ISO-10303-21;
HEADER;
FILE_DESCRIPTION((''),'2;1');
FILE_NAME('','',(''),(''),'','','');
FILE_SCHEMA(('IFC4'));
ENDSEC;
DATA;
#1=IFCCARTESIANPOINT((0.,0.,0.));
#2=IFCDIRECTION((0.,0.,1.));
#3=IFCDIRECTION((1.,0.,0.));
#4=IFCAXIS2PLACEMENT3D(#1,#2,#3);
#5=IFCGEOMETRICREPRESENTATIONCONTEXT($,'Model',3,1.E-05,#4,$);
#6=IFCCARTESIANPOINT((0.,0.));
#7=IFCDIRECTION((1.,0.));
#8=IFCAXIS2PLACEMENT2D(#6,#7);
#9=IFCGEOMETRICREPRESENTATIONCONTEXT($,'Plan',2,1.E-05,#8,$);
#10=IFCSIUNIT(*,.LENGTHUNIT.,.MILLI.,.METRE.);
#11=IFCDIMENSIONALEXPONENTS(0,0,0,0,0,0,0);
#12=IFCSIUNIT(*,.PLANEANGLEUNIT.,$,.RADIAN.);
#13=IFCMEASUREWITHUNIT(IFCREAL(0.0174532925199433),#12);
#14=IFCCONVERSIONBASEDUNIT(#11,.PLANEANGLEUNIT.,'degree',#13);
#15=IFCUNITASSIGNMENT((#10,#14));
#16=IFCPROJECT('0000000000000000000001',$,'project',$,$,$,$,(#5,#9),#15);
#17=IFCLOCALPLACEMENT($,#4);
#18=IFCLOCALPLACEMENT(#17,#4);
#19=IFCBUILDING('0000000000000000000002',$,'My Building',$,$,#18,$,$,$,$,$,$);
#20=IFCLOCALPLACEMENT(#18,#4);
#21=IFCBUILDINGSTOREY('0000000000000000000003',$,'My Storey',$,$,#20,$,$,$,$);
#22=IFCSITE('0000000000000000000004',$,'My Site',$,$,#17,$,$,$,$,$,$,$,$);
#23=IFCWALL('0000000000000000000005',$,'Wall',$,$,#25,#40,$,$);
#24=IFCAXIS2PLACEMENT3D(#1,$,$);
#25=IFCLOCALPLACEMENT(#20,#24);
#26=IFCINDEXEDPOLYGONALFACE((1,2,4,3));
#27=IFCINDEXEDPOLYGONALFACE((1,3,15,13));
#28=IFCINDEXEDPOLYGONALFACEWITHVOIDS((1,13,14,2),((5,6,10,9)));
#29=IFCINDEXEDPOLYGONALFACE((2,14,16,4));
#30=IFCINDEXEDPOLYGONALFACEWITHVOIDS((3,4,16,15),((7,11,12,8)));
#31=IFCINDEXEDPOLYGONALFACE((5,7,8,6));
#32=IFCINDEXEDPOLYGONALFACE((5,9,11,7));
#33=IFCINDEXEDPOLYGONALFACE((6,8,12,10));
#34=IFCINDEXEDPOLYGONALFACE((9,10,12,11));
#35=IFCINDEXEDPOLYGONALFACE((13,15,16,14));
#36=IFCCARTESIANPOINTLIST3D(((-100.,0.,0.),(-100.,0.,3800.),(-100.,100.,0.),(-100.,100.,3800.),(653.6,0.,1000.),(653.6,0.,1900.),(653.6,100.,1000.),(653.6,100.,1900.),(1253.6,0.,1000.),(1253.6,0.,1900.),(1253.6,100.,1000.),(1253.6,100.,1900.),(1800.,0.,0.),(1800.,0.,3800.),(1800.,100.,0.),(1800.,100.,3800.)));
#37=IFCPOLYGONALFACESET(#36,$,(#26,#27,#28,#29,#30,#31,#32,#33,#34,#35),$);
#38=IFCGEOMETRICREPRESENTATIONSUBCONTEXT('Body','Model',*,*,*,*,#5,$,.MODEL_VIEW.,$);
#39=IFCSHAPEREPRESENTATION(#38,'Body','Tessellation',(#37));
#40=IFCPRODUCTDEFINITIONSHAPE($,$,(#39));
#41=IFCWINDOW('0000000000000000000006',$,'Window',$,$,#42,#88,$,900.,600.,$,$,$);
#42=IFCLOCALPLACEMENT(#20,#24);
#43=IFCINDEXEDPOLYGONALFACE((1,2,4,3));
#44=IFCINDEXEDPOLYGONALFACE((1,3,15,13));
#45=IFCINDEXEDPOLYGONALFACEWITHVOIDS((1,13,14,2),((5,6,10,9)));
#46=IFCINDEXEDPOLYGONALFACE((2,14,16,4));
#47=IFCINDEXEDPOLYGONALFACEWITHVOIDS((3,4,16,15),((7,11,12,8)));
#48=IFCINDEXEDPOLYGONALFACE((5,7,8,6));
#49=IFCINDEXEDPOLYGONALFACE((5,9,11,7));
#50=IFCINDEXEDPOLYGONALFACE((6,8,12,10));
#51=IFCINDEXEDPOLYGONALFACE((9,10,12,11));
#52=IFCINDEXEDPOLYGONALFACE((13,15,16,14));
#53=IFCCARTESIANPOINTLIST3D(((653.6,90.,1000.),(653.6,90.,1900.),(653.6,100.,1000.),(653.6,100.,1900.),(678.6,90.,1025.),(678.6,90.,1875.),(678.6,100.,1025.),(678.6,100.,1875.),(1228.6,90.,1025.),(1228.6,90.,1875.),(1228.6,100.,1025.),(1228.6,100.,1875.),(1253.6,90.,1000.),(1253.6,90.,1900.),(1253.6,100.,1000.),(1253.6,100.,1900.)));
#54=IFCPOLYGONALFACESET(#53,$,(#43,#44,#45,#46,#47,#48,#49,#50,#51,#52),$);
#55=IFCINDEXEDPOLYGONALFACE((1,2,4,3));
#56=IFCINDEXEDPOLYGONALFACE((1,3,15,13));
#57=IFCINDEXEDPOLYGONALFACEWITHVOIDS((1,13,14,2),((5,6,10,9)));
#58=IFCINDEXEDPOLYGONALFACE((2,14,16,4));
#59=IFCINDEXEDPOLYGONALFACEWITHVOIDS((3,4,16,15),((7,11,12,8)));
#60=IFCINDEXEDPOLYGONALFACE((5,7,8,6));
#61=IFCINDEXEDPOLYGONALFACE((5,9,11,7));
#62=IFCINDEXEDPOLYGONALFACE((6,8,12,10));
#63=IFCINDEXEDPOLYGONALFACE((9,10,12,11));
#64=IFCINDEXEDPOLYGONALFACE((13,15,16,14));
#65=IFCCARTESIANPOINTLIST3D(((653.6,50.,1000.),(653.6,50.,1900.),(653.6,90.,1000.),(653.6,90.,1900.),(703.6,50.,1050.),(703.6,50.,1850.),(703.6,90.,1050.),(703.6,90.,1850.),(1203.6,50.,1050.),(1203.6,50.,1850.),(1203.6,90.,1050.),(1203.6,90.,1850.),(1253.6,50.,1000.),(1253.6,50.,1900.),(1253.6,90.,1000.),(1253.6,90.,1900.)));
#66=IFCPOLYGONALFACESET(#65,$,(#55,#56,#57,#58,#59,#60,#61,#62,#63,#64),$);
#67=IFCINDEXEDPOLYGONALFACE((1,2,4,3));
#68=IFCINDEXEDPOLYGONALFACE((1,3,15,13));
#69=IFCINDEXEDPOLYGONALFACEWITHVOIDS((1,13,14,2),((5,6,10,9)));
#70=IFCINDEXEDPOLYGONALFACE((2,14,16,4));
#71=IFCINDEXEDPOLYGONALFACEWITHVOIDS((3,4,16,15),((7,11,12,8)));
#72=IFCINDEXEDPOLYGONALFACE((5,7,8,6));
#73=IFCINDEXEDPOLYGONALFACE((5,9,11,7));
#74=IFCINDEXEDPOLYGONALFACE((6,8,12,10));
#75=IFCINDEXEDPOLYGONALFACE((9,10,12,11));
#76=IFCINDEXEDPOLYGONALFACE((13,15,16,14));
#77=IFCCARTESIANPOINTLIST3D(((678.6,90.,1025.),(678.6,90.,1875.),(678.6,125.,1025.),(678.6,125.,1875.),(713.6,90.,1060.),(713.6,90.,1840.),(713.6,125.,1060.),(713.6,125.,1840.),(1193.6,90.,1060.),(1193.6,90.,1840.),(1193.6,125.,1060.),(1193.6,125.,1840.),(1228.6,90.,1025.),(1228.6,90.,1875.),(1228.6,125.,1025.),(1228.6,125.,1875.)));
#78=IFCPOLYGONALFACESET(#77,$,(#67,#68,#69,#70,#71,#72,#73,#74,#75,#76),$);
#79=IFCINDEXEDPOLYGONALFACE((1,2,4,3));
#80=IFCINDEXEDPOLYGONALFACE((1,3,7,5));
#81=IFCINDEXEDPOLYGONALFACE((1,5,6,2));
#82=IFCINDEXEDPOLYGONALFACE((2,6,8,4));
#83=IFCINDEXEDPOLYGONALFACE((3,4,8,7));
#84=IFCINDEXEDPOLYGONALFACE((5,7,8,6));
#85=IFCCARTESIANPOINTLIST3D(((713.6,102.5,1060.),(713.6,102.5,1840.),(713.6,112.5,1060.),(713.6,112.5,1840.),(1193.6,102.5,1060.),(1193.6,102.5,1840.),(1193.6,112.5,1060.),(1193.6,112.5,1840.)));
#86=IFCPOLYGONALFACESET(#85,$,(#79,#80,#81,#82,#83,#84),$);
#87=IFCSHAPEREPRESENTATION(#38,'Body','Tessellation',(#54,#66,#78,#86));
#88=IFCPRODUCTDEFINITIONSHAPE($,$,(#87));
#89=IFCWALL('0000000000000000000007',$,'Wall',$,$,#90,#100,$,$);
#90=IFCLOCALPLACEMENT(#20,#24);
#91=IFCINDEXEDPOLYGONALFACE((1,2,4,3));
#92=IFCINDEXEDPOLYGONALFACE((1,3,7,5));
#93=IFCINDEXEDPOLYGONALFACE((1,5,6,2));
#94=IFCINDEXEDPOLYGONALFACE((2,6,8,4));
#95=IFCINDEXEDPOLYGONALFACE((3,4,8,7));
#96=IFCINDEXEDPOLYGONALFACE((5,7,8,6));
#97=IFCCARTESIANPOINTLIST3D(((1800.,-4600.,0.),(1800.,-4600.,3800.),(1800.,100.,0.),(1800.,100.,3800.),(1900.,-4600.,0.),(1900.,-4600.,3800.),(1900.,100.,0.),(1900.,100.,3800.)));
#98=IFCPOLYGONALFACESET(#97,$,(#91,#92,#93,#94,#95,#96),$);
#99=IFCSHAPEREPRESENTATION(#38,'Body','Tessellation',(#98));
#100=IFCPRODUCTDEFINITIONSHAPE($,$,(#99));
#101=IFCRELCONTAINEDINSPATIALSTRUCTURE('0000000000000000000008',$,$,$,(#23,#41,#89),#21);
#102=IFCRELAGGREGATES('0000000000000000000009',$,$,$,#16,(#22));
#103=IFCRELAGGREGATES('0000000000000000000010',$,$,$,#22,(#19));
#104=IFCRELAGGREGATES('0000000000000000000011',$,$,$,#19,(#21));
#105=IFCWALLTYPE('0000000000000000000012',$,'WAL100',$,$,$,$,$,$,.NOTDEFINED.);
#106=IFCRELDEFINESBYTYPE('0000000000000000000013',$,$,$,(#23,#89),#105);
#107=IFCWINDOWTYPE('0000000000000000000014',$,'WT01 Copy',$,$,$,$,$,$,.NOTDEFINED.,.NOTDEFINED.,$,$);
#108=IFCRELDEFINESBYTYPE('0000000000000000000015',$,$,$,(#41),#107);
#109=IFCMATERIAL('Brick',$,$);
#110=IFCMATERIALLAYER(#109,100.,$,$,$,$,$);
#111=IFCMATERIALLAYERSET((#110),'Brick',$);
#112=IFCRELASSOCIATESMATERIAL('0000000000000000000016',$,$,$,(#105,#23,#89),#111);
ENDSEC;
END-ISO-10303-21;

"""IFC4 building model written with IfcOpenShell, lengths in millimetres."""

from ifc_helpers import new_model, entity, si_unit, converted_unit, frame, origin_with_axes, origin_2d_with_axis, place, context, subcontext, project, spatial, line, indexed_curve, outline, extrude, shape, source, transform, mapped, material, layer, layer_set, layer_usage, type_object, type_shapes, element, fill, save


model = new_model("IFC4")

# Units and contexts
model_context = context("Model", 3, precision=1e-05, world=origin_with_axes())
plan_context = context("Plan", 2, precision=1e-05, world=origin_2d_with_axis())
body_context_1 = subcontext(model_context, "Body", "Model", "MODEL_VIEW")
body_context_2 = subcontext(plan_context, "Body", "Plan", "PLAN_VIEW")
ifc_project = project(units=[si_unit("LENGTHUNIT", "METRE", prefix="MILLI"), converted_unit("PLANEANGLEUNIT", "degree", entity("IfcReal", 0.0174532925199433), si_unit("PLANEANGLEUNIT", "RADIAN"), dimensions=[0, 0, 0, 0, 0, 0, 0])], contexts=[model_context, plan_context])

# Site, building, storey
site_placement = place(None, origin_with_axes())
site = spatial("IfcSite", under=ifc_project, at=site_placement, Name="My Site")
building_placement = place(site_placement, origin_with_axes())
building = spatial("IfcBuilding", under=site, at=building_placement, Name="My Building")
storey_placement = place(building_placement, origin_with_axes())
storey = spatial("IfcBuildingStorey", under=building, at=storey_placement, Name="My Storey")

# Wall, opening, window
ifc_material = material(Name="Brick")
ifc_layer_1 = layer(ifc_material, 100.0)
ifc_layer_set_1 = layer_set([ifc_layer_1], Name="Brick")
ifc_layer_usage_1 = layer_usage(ifc_layer_set_1, "AXIS2", "POSITIVE", 0.0)
wall_type = type_object("IfcWallType", Name="WAL100", PredefinedType="NOTDEFINED", material=ifc_layer_set_1)
wall_1_placement = place(storey_placement, frame((-100.0, 0.0, 0.0), z_axis=(0.0, 0.0, 1.0), x_axis=(1.0, 0.0, 0.0)))
wall_1 = element("IfcWall", 1, at=wall_1_placement, inside=storey, type_object=wall_type, material=ifc_layer_usage_1, Name="Wall", context=body_context_1, shape_type="SweptSolid", body=[
    extrude(outline(indexed_curve([(0.0, 0.0), (0.0, 100.0), (1900.0, 100.0), (1900.0, 0.0), (0.0, 0.0)], self_intersect=False)), origin_with_axes(), (0.0, 0.0, 1.0), 3800.0),
])
shared_shape_1 = source(origin_with_axes(), body_context_1, "Body", "SweptSolid", [
    extrude(outline(indexed_curve([(0.0, 0.0), (600.0, 0.0), (600.0, 900.0), (0.0, 900.0)], segments=[line(1, 2, 3, 4, 1)])), frame((0.0, -100.0, 0.0), z_axis=(0.0, -1.0, 0.0), x_axis=(1.0, 0.0, 0.0)), (0.0, 0.0, -1.0), 300.0),
])
opening_1_placement = place(wall_1_placement, frame((753.6, 0.0, 1000.0), z_axis=(0.0, 0.0, 1.0), x_axis=(1.0, 0.0, 0.0)))
opening_1 = element("IfcOpeningElement", 2, at=opening_1_placement, cuts=wall_1, PredefinedType="OPENING", context=body_context_1, shape_type="MappedRepresentation", body=[
    mapped(shared_shape_1, transform((0.0, 0.0, 0.0), x_axis=(1.0, 0.0, 0.0), y_axis=(0.0, 1.0, 0.0), z_axis=(0.0, 0.0, 1.0), scale=1.0)),
])
window_type_1 = type_object("IfcWindowType", Name="WT01 Copy", PartitioningType="NOTDEFINED", PredefinedType="NOTDEFINED")
shared_shape_2 = source(origin_with_axes(), body_context_1, "Body", "SweptSolid", [
    extrude(outline(indexed_curve([(0.0, 0.0), (600.0, 0.0), (600.0, 900.0), (0.0, 900.0)], segments=[line(1, 2, 3, 4, 1)]), holes=[indexed_curve([(25.0, 25.0), (575.0, 25.0), (575.0, 875.0), (25.0, 875.0)], segments=[line(1, 2, 3, 4, 1)])]), frame((0.0, 90.0, 0.0), z_axis=(0.0, -1.0, 0.0), x_axis=(1.0, 0.0, 0.0)), (0.0, 0.0, -1.0), 10.0),
    extrude(outline(indexed_curve([(0.0, 0.0), (600.0, 0.0), (600.0, 900.0), (0.0, 900.0)], segments=[line(1, 2, 3, 4, 1)]), holes=[indexed_curve([(50.0, 50.0), (550.0, 50.0), (550.0, 850.0), (50.0, 850.0)], segments=[line(1, 2, 3, 4, 1)])]), frame((0.0, 50.0, 0.0), z_axis=(0.0, -1.0, 0.0), x_axis=(1.0, 0.0, 0.0)), (0.0, 0.0, -1.0), 40.0),
    extrude(outline(indexed_curve([(0.0, 0.0), (550.0, 0.0), (550.0, 850.0), (0.0, 850.0)], segments=[line(1, 2, 3, 4, 1)]), holes=[indexed_curve([(35.0, 35.0), (515.0, 35.0), (515.0, 815.0), (35.0, 815.0)], segments=[line(1, 2, 3, 4, 1)])]), frame((25.0, 90.0, 25.0), z_axis=(0.0, -1.0, 0.0), x_axis=(1.0, 0.0, 0.0)), (0.0, 0.0, -1.0), 35.0),
    extrude(outline(indexed_curve([(35.0, 35.0), (515.0, 35.0), (515.0, 815.0), (35.0, 815.0)], segments=[line(1, 2, 3, 4, 1)])), frame((25.0, 102.5, 25.0), z_axis=(0.0, -1.0, 0.0), x_axis=(1.0, 0.0, 0.0)), (0.0, 0.0, -1.0), 10.0),
])
shared_shape_3 = source(origin_with_axes(), body_context_2, "Body", "Curve2D", [
    entity("IfcIndexedPolyCurve", entity("IfcCartesianPointList2D", [[50.0, 50.0], [550.0, 50.0]])),
    entity("IfcIndexedPolyCurve", entity("IfcCartesianPointList2D", [[0.0, 100.0], [25.0, 100.0], [25.0, 90.0], [50.0, 90.0], [50.0, 50.0], [0.0, 50.0]]), [entity("IfcLineIndex", [1, 2, 3, 4, 5, 6, 1])]),
    entity("IfcIndexedPolyCurve", entity("IfcCartesianPointList2D", [[600.0, 100.0], [575.0, 100.0], [575.0, 90.0], [550.0, 90.0], [550.0, 50.0], [600.0, 50.0]]), [entity("IfcLineIndex", [1, 2, 3, 4, 5, 6, 1])]),
    entity("IfcIndexedPolyCurve", entity("IfcCartesianPointList2D", [[25.0, 90.0], [60.0, 90.0], [60.0, 125.0], [25.0, 125.0]]), [entity("IfcLineIndex", [1, 2, 3, 4, 1])]),
    entity("IfcIndexedPolyCurve", entity("IfcCartesianPointList2D", [[575.0, 90.0], [540.0, 90.0], [540.0, 125.0], [575.0, 125.0]]), [entity("IfcLineIndex", [1, 2, 3, 4, 1])]),
    entity("IfcIndexedPolyCurve", entity("IfcCartesianPointList2D", [[60.0, 90.0], [540.0, 90.0]])),
    entity("IfcIndexedPolyCurve", entity("IfcCartesianPointList2D", [[60.0, 125.0], [540.0, 125.0]])),
    entity("IfcIndexedPolyCurve", entity("IfcCartesianPointList2D", [[60.0, 107.5], [540.0, 107.5]])),
])
type_shapes(window_type_1, [shared_shape_2, shared_shape_3])
window_1_placement = place(opening_1_placement, origin_with_axes())
window_1 = element("IfcWindow", 3, at=window_1_placement, inside=storey, type_object=window_type_1, Name="Window", OverallHeight=900.0, OverallWidth=600.0, shapes=[
    shape(body_context_1, "Body", "MappedRepresentation", [mapped(shared_shape_2, transform((0.0, 0.0, 0.0), x_axis=(1.0, 0.0, 0.0), y_axis=(0.0, 1.0, 0.0), z_axis=(0.0, 0.0, 1.0), scale=1.0))]),
    shape(body_context_2, "Body", "MappedRepresentation", [mapped(shared_shape_3, transform((0.0, 0.0, 0.0), x_axis=(1.0, 0.0, 0.0), y_axis=(0.0, 1.0, 0.0), z_axis=(0.0, 0.0, 1.0), scale=1.0))]),
])
fill(opening_1, window_1)

# Wall
ifc_layer_usage_2 = layer_usage(ifc_layer_set_1, "AXIS2", "POSITIVE", 0.0)
wall_2_placement = place(storey_placement, frame((1800.0, 100.0, 0.0), z_axis=(0.0, 0.0, 1.0), x_axis=(-0.000001, -1.0, 0.0)))
element("IfcWall", 4, at=wall_2_placement, inside=storey, type_object=wall_type, material=ifc_layer_usage_2, Name="Wall", context=body_context_1, shape_type="SweptSolid", body=[
    extrude(outline(indexed_curve([(0.0, 0.0), (0.0, 100.0), (4700.0, 100.0), (4700.0, 0.0), (0.0, 0.0)], self_intersect=False)), origin_with_axes(), (0.0, 0.0, 1.0), 3800.0),
])

save(model, "model.ifc")
